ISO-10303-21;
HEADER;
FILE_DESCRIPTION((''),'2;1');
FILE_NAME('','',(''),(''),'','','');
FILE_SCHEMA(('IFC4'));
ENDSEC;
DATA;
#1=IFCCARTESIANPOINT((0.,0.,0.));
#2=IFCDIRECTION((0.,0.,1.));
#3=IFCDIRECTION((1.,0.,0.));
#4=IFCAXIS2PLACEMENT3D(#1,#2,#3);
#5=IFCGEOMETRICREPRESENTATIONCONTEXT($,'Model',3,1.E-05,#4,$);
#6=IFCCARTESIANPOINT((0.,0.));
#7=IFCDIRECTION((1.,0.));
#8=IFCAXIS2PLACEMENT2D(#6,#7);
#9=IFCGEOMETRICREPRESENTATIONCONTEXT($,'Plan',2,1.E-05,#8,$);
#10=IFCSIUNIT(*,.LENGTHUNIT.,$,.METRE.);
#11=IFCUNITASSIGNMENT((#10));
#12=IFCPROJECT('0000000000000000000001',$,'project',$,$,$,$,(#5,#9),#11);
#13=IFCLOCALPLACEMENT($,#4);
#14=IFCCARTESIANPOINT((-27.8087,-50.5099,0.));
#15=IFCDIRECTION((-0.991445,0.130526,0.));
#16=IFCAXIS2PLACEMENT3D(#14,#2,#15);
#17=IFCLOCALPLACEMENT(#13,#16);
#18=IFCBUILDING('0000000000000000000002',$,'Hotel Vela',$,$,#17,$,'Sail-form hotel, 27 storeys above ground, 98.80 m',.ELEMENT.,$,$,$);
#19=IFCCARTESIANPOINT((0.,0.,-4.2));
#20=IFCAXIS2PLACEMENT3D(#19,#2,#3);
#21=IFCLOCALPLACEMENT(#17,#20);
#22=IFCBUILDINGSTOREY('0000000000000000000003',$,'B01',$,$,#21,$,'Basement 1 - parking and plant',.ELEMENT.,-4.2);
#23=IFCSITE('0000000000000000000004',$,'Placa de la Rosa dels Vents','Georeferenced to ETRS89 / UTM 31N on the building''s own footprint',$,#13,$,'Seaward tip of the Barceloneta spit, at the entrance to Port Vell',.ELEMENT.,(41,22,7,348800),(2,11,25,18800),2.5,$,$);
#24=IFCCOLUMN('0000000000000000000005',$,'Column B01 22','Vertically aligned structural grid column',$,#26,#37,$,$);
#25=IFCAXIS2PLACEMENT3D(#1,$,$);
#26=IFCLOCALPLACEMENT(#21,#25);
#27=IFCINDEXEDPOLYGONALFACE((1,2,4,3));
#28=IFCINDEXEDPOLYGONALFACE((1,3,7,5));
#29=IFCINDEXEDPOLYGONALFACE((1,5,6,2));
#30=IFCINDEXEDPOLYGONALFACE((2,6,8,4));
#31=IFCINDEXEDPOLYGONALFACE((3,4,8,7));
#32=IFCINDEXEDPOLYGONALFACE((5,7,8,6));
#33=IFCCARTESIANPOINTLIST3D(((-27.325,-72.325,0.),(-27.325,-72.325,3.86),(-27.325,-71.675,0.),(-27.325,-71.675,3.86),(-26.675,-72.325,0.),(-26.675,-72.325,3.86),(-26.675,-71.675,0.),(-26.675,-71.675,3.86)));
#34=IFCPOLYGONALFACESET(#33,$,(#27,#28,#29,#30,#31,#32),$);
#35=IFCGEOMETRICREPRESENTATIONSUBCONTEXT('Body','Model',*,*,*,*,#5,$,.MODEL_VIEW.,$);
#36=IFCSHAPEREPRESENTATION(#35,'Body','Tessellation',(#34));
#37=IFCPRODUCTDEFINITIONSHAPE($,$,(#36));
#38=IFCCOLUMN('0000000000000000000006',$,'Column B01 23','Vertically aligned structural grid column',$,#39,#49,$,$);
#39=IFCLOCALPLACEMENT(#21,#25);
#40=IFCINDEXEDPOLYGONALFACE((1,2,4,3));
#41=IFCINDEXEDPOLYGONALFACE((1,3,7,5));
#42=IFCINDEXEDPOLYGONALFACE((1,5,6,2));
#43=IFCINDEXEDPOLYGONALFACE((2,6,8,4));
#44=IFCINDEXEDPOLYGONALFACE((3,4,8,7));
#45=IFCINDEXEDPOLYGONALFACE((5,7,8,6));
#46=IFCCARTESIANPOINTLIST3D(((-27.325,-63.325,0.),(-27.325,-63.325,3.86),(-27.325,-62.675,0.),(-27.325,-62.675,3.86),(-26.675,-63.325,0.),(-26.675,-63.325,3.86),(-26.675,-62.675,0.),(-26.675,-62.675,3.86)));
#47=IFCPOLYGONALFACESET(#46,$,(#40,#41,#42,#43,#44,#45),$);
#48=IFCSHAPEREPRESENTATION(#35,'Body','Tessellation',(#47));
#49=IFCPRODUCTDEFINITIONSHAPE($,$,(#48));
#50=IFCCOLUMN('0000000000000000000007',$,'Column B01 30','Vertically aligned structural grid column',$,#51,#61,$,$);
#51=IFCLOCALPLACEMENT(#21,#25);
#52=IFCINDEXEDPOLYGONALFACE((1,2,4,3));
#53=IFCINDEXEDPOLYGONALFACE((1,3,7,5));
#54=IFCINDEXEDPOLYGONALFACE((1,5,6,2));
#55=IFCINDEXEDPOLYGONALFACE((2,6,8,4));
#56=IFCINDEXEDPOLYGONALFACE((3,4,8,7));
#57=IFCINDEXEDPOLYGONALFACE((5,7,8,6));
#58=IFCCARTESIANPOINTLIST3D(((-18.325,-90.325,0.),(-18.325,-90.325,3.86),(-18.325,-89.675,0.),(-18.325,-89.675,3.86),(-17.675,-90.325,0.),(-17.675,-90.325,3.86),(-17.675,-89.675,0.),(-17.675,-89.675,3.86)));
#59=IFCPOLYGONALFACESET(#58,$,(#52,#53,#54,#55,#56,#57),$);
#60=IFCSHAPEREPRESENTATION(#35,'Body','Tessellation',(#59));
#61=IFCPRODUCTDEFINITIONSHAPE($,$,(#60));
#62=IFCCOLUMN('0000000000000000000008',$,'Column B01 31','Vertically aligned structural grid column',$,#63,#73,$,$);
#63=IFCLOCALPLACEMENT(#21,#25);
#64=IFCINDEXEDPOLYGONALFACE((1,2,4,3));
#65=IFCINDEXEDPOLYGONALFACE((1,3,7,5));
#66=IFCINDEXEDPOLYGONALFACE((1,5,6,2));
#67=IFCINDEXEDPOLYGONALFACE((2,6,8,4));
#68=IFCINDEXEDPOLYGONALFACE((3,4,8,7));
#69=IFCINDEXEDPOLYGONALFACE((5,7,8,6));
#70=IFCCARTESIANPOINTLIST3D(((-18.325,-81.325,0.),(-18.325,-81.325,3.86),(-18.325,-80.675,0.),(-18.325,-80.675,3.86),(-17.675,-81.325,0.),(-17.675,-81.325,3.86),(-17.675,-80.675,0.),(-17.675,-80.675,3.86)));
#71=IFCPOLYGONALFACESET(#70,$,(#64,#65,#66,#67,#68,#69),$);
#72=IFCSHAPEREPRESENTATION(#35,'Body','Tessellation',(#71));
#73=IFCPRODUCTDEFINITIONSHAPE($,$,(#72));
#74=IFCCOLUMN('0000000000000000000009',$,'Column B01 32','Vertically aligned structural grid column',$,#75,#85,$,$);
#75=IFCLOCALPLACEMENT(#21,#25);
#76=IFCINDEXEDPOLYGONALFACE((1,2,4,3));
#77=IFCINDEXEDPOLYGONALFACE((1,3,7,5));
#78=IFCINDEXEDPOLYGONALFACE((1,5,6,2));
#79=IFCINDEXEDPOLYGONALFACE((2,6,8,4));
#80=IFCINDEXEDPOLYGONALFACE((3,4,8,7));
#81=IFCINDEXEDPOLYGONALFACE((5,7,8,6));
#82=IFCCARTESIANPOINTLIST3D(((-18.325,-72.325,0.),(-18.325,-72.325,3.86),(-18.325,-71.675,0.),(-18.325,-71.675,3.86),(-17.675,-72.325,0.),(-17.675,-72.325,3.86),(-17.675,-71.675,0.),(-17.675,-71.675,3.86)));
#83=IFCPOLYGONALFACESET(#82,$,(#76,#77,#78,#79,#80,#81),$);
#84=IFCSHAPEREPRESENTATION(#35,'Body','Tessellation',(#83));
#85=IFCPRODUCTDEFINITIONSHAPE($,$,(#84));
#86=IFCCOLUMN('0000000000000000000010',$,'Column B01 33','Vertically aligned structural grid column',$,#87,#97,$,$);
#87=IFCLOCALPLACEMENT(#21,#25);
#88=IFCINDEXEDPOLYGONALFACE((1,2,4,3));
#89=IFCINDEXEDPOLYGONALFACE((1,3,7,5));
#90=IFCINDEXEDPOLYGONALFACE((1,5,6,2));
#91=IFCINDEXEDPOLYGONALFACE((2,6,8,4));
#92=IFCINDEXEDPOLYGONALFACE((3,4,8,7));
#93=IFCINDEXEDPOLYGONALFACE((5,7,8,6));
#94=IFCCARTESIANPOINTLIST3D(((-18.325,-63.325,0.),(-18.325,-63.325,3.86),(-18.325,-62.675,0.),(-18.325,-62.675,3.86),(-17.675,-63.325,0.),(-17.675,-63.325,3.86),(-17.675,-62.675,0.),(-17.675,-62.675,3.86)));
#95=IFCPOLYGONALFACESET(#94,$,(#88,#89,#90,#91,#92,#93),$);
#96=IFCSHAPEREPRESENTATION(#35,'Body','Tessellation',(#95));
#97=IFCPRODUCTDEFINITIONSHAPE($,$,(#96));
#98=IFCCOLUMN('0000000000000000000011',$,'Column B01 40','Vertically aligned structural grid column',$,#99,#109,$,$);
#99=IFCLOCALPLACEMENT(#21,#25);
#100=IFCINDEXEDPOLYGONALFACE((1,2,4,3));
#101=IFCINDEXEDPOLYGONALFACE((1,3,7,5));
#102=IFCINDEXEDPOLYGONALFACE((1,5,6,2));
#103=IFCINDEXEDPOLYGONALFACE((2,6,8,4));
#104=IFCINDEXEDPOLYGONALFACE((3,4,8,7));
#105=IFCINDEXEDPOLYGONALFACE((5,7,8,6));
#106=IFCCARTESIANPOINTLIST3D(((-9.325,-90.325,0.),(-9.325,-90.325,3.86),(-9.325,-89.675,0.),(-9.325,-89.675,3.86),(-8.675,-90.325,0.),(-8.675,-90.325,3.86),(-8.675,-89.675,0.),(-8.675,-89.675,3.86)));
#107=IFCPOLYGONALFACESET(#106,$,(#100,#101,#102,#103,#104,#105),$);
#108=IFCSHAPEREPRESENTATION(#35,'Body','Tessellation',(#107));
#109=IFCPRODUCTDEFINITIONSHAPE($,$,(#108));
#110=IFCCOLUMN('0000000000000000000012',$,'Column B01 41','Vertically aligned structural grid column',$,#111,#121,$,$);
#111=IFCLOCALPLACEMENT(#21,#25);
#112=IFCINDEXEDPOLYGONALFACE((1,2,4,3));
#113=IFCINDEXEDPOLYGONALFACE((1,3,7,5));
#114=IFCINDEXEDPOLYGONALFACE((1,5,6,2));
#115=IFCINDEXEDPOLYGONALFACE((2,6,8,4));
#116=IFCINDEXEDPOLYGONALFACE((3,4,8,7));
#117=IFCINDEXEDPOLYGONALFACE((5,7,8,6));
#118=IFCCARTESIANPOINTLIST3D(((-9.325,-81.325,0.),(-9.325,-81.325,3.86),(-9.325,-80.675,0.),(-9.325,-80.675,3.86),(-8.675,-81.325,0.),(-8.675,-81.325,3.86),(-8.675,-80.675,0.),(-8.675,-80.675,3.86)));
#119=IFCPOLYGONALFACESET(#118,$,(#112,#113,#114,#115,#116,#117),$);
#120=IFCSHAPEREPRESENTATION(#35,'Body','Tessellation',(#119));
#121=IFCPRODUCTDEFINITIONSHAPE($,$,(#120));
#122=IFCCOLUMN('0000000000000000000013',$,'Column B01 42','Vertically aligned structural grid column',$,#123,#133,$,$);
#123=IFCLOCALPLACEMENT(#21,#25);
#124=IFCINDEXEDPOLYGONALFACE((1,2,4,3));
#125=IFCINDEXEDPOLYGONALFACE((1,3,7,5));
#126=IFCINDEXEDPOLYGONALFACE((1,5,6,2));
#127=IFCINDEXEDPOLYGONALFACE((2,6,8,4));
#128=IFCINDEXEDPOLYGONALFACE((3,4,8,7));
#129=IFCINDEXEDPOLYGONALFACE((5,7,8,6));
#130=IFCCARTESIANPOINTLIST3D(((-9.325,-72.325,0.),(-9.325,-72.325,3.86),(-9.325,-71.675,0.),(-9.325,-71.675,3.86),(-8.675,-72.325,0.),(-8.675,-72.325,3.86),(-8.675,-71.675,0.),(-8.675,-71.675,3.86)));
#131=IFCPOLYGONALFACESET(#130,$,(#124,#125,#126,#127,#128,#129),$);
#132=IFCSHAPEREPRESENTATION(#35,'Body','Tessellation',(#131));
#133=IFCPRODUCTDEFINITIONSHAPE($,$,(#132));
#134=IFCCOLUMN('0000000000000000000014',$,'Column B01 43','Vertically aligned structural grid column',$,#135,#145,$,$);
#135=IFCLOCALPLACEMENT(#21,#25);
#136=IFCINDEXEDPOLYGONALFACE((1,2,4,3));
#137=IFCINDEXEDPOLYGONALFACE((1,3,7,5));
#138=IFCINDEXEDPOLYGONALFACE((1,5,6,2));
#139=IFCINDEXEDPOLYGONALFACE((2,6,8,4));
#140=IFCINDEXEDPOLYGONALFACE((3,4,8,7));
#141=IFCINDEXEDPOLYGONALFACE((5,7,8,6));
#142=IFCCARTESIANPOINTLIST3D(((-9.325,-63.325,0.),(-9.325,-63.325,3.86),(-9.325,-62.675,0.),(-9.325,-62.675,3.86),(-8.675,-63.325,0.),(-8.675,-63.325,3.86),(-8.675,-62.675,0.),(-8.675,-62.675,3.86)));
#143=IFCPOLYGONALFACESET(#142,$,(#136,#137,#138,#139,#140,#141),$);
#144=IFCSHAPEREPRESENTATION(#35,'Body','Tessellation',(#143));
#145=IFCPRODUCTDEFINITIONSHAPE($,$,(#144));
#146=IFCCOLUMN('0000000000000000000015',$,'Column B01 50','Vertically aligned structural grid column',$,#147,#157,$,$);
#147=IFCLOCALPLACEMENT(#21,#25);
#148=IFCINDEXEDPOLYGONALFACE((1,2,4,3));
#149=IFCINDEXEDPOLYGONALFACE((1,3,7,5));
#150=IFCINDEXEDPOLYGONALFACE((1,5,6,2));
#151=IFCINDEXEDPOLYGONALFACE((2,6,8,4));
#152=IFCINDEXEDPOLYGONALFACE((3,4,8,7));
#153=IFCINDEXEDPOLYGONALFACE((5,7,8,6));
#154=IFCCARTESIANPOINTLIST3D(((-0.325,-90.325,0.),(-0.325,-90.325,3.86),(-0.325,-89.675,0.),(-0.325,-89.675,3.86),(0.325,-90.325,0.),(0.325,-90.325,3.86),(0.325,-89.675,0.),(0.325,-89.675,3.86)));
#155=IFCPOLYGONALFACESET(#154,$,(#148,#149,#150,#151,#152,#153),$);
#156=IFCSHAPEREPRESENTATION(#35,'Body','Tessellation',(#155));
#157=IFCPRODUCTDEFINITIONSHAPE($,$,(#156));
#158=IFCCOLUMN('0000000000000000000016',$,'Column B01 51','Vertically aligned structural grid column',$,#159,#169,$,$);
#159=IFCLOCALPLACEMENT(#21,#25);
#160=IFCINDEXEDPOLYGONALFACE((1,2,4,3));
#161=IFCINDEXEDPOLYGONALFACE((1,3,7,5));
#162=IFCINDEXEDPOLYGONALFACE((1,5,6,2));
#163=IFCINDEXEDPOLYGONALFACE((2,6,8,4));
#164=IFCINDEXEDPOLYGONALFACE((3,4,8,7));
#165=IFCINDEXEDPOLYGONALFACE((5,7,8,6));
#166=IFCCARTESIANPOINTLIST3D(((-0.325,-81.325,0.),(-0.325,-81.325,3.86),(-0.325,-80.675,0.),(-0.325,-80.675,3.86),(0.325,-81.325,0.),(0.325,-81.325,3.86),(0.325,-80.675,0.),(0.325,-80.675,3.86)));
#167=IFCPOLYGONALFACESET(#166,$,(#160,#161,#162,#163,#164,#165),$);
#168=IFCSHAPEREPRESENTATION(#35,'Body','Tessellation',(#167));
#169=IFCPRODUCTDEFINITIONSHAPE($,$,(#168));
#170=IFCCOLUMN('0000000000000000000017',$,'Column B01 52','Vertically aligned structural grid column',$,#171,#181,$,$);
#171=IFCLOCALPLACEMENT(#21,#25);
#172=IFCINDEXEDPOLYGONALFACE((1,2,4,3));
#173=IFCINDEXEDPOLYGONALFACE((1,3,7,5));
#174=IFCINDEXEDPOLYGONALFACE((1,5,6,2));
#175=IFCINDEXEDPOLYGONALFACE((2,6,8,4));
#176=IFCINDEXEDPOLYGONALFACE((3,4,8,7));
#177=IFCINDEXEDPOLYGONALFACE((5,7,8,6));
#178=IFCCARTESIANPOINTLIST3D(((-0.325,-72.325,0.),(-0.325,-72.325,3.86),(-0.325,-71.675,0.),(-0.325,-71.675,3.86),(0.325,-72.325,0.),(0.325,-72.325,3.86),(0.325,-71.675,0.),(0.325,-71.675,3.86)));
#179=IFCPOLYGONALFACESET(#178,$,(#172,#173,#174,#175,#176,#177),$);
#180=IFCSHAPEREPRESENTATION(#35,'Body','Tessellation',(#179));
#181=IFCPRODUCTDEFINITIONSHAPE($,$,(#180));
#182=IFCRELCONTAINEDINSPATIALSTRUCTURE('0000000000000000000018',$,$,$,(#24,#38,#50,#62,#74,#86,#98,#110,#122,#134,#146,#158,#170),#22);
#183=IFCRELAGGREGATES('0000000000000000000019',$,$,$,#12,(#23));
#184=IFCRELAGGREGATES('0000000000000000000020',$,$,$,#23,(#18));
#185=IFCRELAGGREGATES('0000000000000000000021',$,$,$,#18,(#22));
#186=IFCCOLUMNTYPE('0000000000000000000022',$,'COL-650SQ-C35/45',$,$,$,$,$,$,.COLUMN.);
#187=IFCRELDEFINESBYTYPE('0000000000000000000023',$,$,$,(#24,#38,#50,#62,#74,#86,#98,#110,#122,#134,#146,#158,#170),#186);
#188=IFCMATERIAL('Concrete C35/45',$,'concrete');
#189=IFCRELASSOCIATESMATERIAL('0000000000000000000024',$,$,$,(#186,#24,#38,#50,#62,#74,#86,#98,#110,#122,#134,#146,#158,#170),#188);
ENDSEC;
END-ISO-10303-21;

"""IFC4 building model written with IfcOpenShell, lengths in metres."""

from ifc_helpers import new_model, si_unit, frame, origin_with_axes, origin_2d_with_axis, place, context, subcontext, project, spatial, line, indexed_curve, rectangle, outline, extrude, material, material_profile, profile_set, profile_usage, type_object, element, save


model = new_model("IFC4")

# Units and contexts
model_context = context("Model", 3, precision=1e-05, world=origin_with_axes())
plan_context = context("Plan", 2, precision=1e-05, world=origin_2d_with_axis())
body_context = subcontext(model_context, "Body", "Model", "MODEL_VIEW")
ifc_project = project(units=[si_unit("LENGTHUNIT", "METRE")], contexts=[model_context, plan_context])

# Site, building, storey
site_placement = place(None, origin_with_axes())
site = spatial("IfcSite", under=ifc_project, at=site_placement, Name="Placa de la Rosa dels Vents", Description="Georeferenced to ETRS89 / UTM 31N on the building's own footprint", LongName="Seaward tip of the Barceloneta spit, at the entrance to Port Vell", CompositionType="ELEMENT", RefLatitude=(41, 22, 7, 348800), RefLongitude=(2, 11, 25, 18800), RefElevation=2.5)
building_placement = place(site_placement, frame((-27.8087, -50.5099, 0.0), z_axis=(0.0, 0.0, 1.0), x_axis=(-0.991445, 0.130526, 0.0)))
building = spatial("IfcBuilding", under=site, at=building_placement, Name="Hotel Vela", LongName="Sail-form hotel, 27 storeys above ground, 98.80 m", CompositionType="ELEMENT")
storey_placement = place(building_placement, frame((0.0, 0.0, -4.2), z_axis=(0.0, 0.0, 1.0), x_axis=(1.0, 0.0, 0.0)))
storey = spatial("IfcBuildingStorey", under=building, at=storey_placement, Name="B01", LongName="Basement 1 - parking and plant", CompositionType="ELEMENT", Elevation=-4.2)

# Columns
ifc_material = material(Name="Concrete C35/45", Category="concrete")
ifc_material_profile = material_profile(ifc_material, rectangle(XDim=0.65, YDim=0.65))
ifc_profile_set = profile_set([ifc_material_profile], Name="COL-650SQ-C35/45")
column_type = type_object("IfcColumnType", Name="COL-650SQ-C35/45", PredefinedType="COLUMN", material=ifc_profile_set)
ifc_profile_usage_1 = profile_usage(ifc_profile_set)
column_1_placement = place(storey_placement, frame((-27.325, -72.325, 0.0), z_axis=(0.0, 0.0, 1.0), x_axis=(1.0, 0.0, 0.0)))
element("IfcColumn", 1, at=column_1_placement, inside=storey, type_object=column_type, material=ifc_profile_usage_1, Name="Column B01 22", Description="Vertically aligned structural grid column", context=body_context, shape_type="SweptSolid", body=[
    extrude(outline(indexed_curve([(0.0, 0.0), (0.65, 0.0), (0.65, 0.65), (0.0, 0.65)], segments=[line(1, 2, 3, 4, 1)])), origin_with_axes(), (0.0, 0.0, 1.0), 3.86),
])
ifc_profile_usage_2 = profile_usage(ifc_profile_set)
column_2_placement = place(storey_placement, frame((-27.325, -63.325, 0.0), z_axis=(0.0, 0.0, 1.0), x_axis=(1.0, 0.0, 0.0)))
element("IfcColumn", 2, at=column_2_placement, inside=storey, type_object=column_type, material=ifc_profile_usage_2, Name="Column B01 23", Description="Vertically aligned structural grid column", context=body_context, shape_type="SweptSolid", body=[
    extrude(outline(indexed_curve([(0.0, 0.0), (0.65, 0.0), (0.65, 0.65), (0.0, 0.65)], segments=[line(1, 2, 3, 4, 1)])), origin_with_axes(), (0.0, 0.0, 1.0), 3.86),
])
ifc_profile_usage_3 = profile_usage(ifc_profile_set)
column_3_placement = place(storey_placement, frame((-18.325, -90.325, 0.0), z_axis=(0.0, 0.0, 1.0), x_axis=(1.0, 0.0, 0.0)))
element("IfcColumn", 3, at=column_3_placement, inside=storey, type_object=column_type, material=ifc_profile_usage_3, Name="Column B01 30", Description="Vertically aligned structural grid column", context=body_context, shape_type="SweptSolid", body=[
    extrude(outline(indexed_curve([(0.0, 0.0), (0.65, 0.0), (0.65, 0.65), (0.0, 0.65)], segments=[line(1, 2, 3, 4, 1)])), origin_with_axes(), (0.0, 0.0, 1.0), 3.86),
])
ifc_profile_usage_4 = profile_usage(ifc_profile_set)
column_4_placement = place(storey_placement, frame((-18.325, -81.325, 0.0), z_axis=(0.0, 0.0, 1.0), x_axis=(1.0, 0.0, 0.0)))
element("IfcColumn", 4, at=column_4_placement, inside=storey, type_object=column_type, material=ifc_profile_usage_4, Name="Column B01 31", Description="Vertically aligned structural grid column", context=body_context, shape_type="SweptSolid", body=[
    extrude(outline(indexed_curve([(0.0, 0.0), (0.65, 0.0), (0.65, 0.65), (0.0, 0.65)], segments=[line(1, 2, 3, 4, 1)])), origin_with_axes(), (0.0, 0.0, 1.0), 3.86),
])
ifc_profile_usage_5 = profile_usage(ifc_profile_set)
column_5_placement = place(storey_placement, frame((-18.325, -72.325, 0.0), z_axis=(0.0, 0.0, 1.0), x_axis=(1.0, 0.0, 0.0)))
element("IfcColumn", 5, at=column_5_placement, inside=storey, type_object=column_type, material=ifc_profile_usage_5, Name="Column B01 32", Description="Vertically aligned structural grid column", context=body_context, shape_type="SweptSolid", body=[
    extrude(outline(indexed_curve([(0.0, 0.0), (0.65, 0.0), (0.65, 0.65), (0.0, 0.65)], segments=[line(1, 2, 3, 4, 1)])), origin_with_axes(), (0.0, 0.0, 1.0), 3.86),
])
ifc_profile_usage_6 = profile_usage(ifc_profile_set)
column_6_placement = place(storey_placement, frame((-18.325, -63.325, 0.0), z_axis=(0.0, 0.0, 1.0), x_axis=(1.0, 0.0, 0.0)))
element("IfcColumn", 6, at=column_6_placement, inside=storey, type_object=column_type, material=ifc_profile_usage_6, Name="Column B01 33", Description="Vertically aligned structural grid column", context=body_context, shape_type="SweptSolid", body=[
    extrude(outline(indexed_curve([(0.0, 0.0), (0.65, 0.0), (0.65, 0.65), (0.0, 0.65)], segments=[line(1, 2, 3, 4, 1)])), origin_with_axes(), (0.0, 0.0, 1.0), 3.86),
])
ifc_profile_usage_7 = profile_usage(ifc_profile_set)
column_7_placement = place(storey_placement, frame((-9.325, -90.325, 0.0), z_axis=(0.0, 0.0, 1.0), x_axis=(1.0, 0.0, 0.0)))
element("IfcColumn", 7, at=column_7_placement, inside=storey, type_object=column_type, material=ifc_profile_usage_7, Name="Column B01 40", Description="Vertically aligned structural grid column", context=body_context, shape_type="SweptSolid", body=[
    extrude(outline(indexed_curve([(0.0, 0.0), (0.65, 0.0), (0.65, 0.65), (0.0, 0.65)], segments=[line(1, 2, 3, 4, 1)])), origin_with_axes(), (0.0, 0.0, 1.0), 3.86),
])
ifc_profile_usage_8 = profile_usage(ifc_profile_set)
column_8_placement = place(storey_placement, frame((-9.325, -81.325, 0.0), z_axis=(0.0, 0.0, 1.0), x_axis=(1.0, 0.0, 0.0)))
element("IfcColumn", 8, at=column_8_placement, inside=storey, type_object=column_type, material=ifc_profile_usage_8, Name="Column B01 41", Description="Vertically aligned structural grid column", context=body_context, shape_type="SweptSolid", body=[
    extrude(outline(indexed_curve([(0.0, 0.0), (0.65, 0.0), (0.65, 0.65), (0.0, 0.65)], segments=[line(1, 2, 3, 4, 1)])), origin_with_axes(), (0.0, 0.0, 1.0), 3.86),
])
ifc_profile_usage_9 = profile_usage(ifc_profile_set)
column_9_placement = place(storey_placement, frame((-9.325, -72.325, 0.0), z_axis=(0.0, 0.0, 1.0), x_axis=(1.0, 0.0, 0.0)))
element("IfcColumn", 9, at=column_9_placement, inside=storey, type_object=column_type, material=ifc_profile_usage_9, Name="Column B01 42", Description="Vertically aligned structural grid column", context=body_context, shape_type="SweptSolid", body=[
    extrude(outline(indexed_curve([(0.0, 0.0), (0.65, 0.0), (0.65, 0.65), (0.0, 0.65)], segments=[line(1, 2, 3, 4, 1)])), origin_with_axes(), (0.0, 0.0, 1.0), 3.86),
])
ifc_profile_usage_10 = profile_usage(ifc_profile_set)
column_10_placement = place(storey_placement, frame((-9.325, -63.325, 0.0), z_axis=(0.0, 0.0, 1.0), x_axis=(1.0, 0.0, 0.0)))
element("IfcColumn", 10, at=column_10_placement, inside=storey, type_object=column_type, material=ifc_profile_usage_10, Name="Column B01 43", Description="Vertically aligned structural grid column", context=body_context, shape_type="SweptSolid", body=[
    extrude(outline(indexed_curve([(0.0, 0.0), (0.65, 0.0), (0.65, 0.65), (0.0, 0.65)], segments=[line(1, 2, 3, 4, 1)])), origin_with_axes(), (0.0, 0.0, 1.0), 3.86),
])
ifc_profile_usage_11 = profile_usage(ifc_profile_set)
column_11_placement = place(storey_placement, frame((-0.325, -90.325, 0.0), z_axis=(0.0, 0.0, 1.0), x_axis=(1.0, 0.0, 0.0)))
element("IfcColumn", 11, at=column_11_placement, inside=storey, type_object=column_type, material=ifc_profile_usage_11, Name="Column B01 50", Description="Vertically aligned structural grid column", context=body_context, shape_type="SweptSolid", body=[
    extrude(outline(indexed_curve([(0.0, 0.0), (0.65, 0.0), (0.65, 0.65), (0.0, 0.65)], segments=[line(1, 2, 3, 4, 1)])), origin_with_axes(), (0.0, 0.0, 1.0), 3.86),
])
ifc_profile_usage_12 = profile_usage(ifc_profile_set)
column_12_placement = place(storey_placement, frame((-0.325, -81.325, 0.0), z_axis=(0.0, 0.0, 1.0), x_axis=(1.0, 0.0, 0.0)))
element("IfcColumn", 12, at=column_12_placement, inside=storey, type_object=column_type, material=ifc_profile_usage_12, Name="Column B01 51", Description="Vertically aligned structural grid column", context=body_context, shape_type="SweptSolid", body=[
    extrude(outline(indexed_curve([(0.0, 0.0), (0.65, 0.0), (0.65, 0.65), (0.0, 0.65)], segments=[line(1, 2, 3, 4, 1)])), origin_with_axes(), (0.0, 0.0, 1.0), 3.86),
])
ifc_profile_usage_13 = profile_usage(ifc_profile_set)
column_13_placement = place(storey_placement, frame((-0.325, -72.325, 0.0), z_axis=(0.0, 0.0, 1.0), x_axis=(1.0, 0.0, 0.0)))
element("IfcColumn", 13, at=column_13_placement, inside=storey, type_object=column_type, material=ifc_profile_usage_13, Name="Column B01 52", Description="Vertically aligned structural grid column", context=body_context, shape_type="SweptSolid", body=[
    extrude(outline(indexed_curve([(0.0, 0.0), (0.65, 0.0), (0.65, 0.65), (0.0, 0.65)], segments=[line(1, 2, 3, 4, 1)])), origin_with_axes(), (0.0, 0.0, 1.0), 3.86),
])

save(model, "model.ifc")
